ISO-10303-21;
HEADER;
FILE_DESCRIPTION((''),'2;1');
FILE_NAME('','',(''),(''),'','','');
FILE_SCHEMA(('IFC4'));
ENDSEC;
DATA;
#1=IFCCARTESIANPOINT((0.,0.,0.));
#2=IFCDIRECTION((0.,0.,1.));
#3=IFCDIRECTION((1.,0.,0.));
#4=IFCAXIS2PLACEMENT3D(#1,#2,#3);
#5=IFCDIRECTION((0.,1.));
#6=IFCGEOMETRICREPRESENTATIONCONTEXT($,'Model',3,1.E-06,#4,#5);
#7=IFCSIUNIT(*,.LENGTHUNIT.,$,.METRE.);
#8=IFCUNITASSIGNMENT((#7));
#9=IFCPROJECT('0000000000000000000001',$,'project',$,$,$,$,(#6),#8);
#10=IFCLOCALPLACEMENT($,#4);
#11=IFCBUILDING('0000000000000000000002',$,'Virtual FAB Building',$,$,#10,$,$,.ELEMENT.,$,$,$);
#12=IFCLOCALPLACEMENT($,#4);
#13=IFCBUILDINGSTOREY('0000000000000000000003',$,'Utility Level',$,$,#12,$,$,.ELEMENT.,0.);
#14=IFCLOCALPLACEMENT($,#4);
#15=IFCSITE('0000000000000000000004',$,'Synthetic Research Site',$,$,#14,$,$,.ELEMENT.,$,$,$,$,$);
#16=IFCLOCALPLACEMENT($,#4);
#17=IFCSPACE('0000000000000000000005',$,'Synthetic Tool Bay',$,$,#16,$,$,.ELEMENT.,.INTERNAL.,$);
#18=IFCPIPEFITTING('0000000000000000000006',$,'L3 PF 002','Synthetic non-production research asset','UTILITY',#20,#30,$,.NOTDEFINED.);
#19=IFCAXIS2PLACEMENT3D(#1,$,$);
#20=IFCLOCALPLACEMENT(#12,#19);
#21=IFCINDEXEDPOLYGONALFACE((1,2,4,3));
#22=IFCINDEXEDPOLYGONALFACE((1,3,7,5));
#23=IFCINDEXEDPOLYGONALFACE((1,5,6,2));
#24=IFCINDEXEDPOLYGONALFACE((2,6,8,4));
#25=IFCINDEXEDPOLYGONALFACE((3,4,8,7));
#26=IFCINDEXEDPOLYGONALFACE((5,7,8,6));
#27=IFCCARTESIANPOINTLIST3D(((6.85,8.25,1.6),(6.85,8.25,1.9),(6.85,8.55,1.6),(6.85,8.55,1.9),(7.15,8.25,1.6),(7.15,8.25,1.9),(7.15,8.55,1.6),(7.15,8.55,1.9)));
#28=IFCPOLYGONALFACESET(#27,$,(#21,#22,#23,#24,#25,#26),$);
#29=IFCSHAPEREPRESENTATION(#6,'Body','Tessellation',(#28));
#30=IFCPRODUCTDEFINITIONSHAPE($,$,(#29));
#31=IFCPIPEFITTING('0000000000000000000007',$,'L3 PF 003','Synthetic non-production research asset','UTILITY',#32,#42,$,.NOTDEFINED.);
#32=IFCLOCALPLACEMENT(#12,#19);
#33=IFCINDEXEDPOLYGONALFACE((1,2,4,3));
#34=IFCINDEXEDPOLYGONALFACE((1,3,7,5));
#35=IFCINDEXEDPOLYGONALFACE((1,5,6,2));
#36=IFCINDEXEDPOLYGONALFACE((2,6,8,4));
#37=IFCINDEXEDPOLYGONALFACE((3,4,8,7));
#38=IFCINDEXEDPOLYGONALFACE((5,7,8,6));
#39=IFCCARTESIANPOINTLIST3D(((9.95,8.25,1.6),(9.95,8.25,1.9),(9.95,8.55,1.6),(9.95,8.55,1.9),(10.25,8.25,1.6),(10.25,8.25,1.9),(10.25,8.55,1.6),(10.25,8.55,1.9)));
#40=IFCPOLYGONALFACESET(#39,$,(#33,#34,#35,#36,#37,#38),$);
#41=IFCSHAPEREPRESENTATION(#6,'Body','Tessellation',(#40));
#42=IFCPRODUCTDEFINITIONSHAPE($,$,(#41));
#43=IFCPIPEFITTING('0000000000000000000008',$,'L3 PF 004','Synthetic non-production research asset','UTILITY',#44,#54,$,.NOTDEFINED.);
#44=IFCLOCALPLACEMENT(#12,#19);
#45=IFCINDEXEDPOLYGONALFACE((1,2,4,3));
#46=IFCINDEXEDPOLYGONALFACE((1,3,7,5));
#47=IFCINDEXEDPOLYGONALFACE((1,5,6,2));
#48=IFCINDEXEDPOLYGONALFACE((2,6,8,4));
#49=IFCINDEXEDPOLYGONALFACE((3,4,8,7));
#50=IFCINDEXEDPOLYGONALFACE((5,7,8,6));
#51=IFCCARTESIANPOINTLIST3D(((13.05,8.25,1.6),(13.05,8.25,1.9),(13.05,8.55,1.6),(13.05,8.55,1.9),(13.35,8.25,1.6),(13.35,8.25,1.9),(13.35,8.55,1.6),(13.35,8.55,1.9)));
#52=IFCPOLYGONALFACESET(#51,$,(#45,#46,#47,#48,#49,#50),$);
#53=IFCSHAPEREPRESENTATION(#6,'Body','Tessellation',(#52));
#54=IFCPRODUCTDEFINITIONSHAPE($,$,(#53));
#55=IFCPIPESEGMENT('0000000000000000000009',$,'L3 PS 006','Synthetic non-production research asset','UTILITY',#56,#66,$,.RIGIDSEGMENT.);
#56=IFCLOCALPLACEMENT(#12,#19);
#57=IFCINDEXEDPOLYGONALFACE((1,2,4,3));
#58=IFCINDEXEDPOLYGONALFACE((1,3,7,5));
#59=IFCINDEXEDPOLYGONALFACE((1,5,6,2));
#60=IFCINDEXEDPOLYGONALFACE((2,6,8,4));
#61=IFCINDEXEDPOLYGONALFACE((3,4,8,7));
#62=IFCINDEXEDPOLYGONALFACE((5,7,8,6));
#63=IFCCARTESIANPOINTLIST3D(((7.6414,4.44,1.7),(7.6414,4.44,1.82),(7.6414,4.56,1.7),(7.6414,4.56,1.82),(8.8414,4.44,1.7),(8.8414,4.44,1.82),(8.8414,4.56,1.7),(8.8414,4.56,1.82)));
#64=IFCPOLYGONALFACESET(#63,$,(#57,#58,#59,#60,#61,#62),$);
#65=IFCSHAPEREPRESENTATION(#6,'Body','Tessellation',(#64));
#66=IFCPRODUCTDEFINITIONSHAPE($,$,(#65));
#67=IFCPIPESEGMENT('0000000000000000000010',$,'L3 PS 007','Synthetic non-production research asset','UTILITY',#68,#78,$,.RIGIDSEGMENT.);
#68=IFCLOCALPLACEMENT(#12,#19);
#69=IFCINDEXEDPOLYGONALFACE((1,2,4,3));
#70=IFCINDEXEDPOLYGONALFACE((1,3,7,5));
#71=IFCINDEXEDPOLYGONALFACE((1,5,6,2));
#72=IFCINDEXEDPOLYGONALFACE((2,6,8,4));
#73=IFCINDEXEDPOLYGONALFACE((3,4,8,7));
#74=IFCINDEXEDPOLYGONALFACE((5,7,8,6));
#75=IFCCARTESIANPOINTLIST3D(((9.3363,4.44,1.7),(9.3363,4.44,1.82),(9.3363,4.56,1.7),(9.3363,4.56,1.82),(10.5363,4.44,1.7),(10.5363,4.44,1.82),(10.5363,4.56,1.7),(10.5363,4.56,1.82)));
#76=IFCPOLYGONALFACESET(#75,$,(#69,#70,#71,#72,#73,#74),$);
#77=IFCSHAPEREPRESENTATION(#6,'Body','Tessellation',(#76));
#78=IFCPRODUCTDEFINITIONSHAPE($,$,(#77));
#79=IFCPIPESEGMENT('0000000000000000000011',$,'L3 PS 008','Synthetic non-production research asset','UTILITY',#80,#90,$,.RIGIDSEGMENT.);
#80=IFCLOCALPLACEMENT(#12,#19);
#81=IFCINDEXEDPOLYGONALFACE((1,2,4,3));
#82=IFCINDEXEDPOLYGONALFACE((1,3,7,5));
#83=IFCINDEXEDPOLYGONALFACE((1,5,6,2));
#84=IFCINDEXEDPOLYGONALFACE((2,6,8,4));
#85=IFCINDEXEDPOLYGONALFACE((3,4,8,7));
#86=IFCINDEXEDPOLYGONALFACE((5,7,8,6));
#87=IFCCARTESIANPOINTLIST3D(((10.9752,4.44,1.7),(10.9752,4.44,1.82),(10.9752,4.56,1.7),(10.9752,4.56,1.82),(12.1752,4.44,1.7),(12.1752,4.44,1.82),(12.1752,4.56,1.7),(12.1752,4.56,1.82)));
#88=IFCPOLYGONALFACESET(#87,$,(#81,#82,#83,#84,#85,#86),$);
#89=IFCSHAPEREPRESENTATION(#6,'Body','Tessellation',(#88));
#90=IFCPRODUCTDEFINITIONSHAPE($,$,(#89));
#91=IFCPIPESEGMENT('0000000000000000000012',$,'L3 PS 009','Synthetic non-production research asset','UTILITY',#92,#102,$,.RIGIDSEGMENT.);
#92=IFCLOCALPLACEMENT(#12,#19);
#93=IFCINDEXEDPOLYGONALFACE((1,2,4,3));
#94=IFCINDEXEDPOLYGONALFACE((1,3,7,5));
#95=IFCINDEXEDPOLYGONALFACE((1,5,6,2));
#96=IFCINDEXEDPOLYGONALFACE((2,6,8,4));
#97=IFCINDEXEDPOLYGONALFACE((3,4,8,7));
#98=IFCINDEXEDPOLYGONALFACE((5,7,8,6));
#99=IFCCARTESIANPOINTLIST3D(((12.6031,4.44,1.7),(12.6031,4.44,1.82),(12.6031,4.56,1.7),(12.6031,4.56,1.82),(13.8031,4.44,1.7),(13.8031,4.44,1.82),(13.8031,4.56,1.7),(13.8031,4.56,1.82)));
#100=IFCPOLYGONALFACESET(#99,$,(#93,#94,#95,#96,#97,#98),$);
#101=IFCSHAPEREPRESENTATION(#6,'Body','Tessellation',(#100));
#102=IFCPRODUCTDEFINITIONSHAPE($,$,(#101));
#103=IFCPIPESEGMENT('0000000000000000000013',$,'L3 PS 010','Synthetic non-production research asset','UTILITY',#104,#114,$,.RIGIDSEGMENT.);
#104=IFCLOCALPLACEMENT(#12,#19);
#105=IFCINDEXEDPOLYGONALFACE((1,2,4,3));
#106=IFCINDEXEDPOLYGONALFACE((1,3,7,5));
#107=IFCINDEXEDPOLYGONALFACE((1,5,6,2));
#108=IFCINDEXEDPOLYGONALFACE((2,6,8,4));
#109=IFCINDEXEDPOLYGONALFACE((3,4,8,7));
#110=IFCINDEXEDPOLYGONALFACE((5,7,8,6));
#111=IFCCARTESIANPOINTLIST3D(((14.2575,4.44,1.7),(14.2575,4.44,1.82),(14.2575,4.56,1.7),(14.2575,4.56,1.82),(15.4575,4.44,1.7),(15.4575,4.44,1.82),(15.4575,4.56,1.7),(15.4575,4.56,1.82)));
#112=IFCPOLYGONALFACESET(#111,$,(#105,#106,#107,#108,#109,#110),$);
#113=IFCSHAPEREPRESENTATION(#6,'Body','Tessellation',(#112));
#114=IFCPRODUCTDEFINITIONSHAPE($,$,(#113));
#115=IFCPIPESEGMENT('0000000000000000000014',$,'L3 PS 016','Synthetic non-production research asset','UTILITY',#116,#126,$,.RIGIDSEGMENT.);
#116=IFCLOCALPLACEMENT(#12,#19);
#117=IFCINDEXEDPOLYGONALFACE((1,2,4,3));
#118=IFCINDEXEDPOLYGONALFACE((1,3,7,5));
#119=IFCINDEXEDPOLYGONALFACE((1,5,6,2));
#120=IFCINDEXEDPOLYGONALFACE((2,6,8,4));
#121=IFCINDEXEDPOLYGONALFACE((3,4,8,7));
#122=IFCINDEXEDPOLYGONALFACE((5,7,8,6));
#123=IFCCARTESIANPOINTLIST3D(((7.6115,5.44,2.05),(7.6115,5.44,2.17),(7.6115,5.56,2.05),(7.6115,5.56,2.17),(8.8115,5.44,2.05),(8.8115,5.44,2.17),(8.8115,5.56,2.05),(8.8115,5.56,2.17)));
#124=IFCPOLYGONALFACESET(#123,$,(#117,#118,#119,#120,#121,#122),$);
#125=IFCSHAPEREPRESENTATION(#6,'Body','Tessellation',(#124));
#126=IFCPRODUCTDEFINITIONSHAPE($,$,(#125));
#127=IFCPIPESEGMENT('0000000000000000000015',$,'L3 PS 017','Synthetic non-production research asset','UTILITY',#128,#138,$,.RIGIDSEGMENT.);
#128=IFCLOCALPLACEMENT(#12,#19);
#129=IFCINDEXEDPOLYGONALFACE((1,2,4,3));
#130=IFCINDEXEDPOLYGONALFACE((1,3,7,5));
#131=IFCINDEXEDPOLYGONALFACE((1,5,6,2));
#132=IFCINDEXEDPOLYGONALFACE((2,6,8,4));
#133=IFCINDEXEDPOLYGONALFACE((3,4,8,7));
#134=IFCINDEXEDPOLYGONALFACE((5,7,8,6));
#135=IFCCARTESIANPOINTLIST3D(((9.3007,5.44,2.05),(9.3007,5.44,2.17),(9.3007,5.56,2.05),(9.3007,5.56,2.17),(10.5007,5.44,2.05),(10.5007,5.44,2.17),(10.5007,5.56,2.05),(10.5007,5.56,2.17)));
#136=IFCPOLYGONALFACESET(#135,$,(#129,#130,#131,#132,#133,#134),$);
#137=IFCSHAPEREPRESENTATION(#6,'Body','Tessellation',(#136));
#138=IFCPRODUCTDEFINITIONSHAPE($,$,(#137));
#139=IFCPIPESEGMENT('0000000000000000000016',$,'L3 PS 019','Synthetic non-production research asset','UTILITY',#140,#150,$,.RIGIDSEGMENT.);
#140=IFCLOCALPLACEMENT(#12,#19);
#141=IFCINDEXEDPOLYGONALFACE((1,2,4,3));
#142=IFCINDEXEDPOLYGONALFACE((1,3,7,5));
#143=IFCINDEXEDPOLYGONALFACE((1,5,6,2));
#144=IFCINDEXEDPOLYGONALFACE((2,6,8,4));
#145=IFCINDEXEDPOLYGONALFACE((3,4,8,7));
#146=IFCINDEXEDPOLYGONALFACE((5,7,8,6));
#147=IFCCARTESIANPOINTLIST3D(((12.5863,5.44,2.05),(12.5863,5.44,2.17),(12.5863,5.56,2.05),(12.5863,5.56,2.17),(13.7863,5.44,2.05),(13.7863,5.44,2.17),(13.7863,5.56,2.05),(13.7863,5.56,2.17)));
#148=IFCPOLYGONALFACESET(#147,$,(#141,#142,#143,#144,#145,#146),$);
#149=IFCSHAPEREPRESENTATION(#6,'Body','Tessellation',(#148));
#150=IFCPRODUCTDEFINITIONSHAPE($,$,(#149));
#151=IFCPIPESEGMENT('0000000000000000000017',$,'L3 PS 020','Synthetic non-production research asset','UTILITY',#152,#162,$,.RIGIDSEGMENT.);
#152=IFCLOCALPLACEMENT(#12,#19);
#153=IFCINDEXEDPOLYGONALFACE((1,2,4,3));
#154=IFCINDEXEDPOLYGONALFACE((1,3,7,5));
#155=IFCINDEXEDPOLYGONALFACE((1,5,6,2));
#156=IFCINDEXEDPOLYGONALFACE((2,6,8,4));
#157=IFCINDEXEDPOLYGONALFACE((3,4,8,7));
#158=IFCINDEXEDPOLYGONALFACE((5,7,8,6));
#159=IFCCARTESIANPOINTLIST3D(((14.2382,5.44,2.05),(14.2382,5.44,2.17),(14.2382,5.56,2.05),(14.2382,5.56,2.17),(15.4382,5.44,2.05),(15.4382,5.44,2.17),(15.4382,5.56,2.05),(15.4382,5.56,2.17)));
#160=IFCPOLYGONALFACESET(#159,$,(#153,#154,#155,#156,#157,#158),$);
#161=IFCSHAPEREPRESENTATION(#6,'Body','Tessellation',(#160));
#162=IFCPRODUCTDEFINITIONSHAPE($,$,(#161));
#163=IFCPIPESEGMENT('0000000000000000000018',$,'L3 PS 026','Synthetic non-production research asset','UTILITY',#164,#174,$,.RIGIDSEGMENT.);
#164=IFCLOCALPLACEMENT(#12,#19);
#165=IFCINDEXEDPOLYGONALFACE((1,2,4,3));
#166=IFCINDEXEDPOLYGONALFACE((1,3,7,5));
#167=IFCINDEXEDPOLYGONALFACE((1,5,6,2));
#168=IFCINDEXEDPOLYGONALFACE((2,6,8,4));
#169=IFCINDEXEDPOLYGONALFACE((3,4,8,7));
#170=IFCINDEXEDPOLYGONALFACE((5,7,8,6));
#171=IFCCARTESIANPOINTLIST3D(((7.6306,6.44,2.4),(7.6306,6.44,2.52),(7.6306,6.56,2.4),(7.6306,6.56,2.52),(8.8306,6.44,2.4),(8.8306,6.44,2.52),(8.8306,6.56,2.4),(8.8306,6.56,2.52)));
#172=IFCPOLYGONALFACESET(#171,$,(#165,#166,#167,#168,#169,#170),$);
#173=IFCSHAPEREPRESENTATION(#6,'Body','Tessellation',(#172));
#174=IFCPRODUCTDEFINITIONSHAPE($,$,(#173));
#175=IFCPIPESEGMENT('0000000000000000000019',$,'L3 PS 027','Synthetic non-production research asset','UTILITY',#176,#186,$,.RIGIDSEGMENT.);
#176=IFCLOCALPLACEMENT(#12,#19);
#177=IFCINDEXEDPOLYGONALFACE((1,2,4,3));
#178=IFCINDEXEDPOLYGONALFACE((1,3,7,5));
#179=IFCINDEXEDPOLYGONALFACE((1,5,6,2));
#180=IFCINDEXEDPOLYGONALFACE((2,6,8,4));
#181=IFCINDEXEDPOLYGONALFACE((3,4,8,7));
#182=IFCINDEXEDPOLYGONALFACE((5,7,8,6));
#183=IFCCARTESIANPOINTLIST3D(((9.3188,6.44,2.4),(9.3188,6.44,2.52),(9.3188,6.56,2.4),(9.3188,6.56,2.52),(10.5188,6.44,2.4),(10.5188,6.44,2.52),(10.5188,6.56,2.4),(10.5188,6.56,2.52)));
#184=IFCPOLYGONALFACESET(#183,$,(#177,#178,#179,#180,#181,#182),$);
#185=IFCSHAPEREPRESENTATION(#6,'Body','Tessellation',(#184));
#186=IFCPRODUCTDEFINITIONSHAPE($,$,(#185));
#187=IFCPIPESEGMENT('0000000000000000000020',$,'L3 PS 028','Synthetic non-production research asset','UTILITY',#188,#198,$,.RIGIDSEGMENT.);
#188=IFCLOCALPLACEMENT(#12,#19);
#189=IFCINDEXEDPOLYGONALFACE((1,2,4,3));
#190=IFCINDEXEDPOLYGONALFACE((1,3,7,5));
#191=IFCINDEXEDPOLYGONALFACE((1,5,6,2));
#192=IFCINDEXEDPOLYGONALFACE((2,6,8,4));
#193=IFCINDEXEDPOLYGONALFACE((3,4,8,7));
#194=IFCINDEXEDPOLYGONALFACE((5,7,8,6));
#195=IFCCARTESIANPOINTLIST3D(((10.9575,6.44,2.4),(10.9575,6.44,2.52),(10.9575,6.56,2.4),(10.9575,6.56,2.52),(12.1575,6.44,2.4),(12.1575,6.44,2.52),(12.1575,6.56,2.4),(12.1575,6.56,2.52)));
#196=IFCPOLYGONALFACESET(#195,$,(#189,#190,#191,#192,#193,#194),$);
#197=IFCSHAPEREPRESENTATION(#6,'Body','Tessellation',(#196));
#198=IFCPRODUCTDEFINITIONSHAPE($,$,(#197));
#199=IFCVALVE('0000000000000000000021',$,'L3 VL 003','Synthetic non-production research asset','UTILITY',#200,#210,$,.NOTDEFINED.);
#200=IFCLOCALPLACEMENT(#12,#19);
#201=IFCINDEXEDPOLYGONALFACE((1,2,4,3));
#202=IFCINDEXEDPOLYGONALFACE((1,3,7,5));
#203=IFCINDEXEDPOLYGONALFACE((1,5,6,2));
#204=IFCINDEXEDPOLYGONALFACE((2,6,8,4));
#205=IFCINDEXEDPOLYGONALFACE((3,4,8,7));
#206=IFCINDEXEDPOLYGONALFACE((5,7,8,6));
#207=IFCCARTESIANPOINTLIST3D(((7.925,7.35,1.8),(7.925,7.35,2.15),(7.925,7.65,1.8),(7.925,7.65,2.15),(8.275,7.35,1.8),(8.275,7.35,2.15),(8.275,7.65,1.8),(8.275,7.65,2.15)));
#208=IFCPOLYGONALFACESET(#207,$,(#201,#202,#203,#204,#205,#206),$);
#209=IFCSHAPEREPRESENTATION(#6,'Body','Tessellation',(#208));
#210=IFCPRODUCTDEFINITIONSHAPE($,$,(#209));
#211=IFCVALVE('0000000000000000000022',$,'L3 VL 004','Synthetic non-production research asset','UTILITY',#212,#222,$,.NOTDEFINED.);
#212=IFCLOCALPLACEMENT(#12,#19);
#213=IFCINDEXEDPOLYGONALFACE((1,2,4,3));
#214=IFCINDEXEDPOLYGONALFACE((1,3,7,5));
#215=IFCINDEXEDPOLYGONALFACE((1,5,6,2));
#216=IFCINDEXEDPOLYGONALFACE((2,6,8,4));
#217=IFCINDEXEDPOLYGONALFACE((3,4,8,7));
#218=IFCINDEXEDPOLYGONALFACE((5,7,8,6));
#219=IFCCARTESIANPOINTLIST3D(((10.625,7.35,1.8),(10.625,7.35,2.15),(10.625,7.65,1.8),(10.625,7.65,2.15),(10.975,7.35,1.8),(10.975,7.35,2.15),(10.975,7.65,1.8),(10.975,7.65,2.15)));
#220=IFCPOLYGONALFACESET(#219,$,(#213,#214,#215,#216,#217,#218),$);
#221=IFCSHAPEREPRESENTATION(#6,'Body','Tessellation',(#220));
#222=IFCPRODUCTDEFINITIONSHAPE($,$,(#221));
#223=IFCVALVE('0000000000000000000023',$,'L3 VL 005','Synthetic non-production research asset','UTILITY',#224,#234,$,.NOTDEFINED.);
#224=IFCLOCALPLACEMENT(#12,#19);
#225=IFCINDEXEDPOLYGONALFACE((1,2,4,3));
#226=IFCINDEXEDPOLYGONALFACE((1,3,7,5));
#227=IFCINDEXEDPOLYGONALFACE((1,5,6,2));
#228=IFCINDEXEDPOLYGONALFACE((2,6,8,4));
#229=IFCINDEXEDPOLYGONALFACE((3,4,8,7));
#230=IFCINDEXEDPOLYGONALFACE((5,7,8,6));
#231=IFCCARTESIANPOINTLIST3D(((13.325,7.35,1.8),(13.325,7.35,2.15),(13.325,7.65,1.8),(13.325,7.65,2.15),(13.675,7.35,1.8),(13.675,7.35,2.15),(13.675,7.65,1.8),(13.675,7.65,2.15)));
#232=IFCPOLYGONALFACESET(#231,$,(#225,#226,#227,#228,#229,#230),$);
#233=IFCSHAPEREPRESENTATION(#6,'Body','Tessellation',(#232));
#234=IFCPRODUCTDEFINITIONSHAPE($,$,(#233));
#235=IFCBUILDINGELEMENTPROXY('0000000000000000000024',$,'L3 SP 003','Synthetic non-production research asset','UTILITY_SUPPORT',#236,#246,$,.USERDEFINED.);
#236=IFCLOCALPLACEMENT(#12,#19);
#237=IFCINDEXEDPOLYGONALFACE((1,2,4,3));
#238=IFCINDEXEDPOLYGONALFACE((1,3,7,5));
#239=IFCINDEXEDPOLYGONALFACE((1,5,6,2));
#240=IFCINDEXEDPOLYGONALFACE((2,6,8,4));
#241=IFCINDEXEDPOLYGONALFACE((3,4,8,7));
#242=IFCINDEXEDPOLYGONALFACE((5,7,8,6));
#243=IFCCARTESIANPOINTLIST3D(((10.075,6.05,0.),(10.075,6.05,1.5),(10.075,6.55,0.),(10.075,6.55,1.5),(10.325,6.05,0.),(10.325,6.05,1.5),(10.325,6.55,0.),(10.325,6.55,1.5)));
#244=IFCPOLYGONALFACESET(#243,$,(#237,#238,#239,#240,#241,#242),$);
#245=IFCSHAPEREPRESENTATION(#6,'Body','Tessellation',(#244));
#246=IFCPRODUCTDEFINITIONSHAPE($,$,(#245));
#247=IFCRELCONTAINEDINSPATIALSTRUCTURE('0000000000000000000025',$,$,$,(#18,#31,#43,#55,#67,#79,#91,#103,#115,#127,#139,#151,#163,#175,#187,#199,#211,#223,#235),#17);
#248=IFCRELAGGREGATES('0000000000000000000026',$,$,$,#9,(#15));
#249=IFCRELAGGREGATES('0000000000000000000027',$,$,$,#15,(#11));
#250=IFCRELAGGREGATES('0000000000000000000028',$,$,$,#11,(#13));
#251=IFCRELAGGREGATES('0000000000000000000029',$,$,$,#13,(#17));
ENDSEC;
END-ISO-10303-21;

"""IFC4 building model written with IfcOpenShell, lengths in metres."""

from ifc_helpers import new_model, si_unit, direction, frame, origin_with_axes, origin_2d_with_axis, place, context, project, spatial, rectangle, extrude, element, save


model = new_model("IFC4")

# Units and contexts
model_context = context("Model", 3, precision=1e-06, world=origin_with_axes(), true_north=direction((0.0, 1.0)))
ifc_project = project(units=[si_unit("LENGTHUNIT", "METRE")], contexts=[model_context])

# Site, building, storey, space
site_placement = place(None, origin_with_axes())
site = spatial("IfcSite", under=ifc_project, at=site_placement, Name="Synthetic Research Site", CompositionType="ELEMENT")
building_placement = place(None, origin_with_axes())
building = spatial("IfcBuilding", under=site, at=building_placement, Name="Virtual FAB Building", CompositionType="ELEMENT")
storey_placement = place(None, origin_with_axes())
storey = spatial("IfcBuildingStorey", under=building, at=storey_placement, Name="Utility Level", CompositionType="ELEMENT", Elevation=0.0)
space_placement = place(None, origin_with_axes())
space = spatial("IfcSpace", under=storey, at=space_placement, Name="Synthetic Tool Bay", CompositionType="ELEMENT", PredefinedType="INTERNAL")

# Pipe fittings
for number, where, z_axis, x_axis, name in (
    (1, (7.0, 8.4, 1.6), (0.0, 0.0, 1.0), (1.0, 0.0, 0.0), "L3 PF 002"),
    (2, (10.1, 8.4, 1.6), (0.0, 0.0, 1.0), (1.0, 0.0, 0.0), "L3 PF 003"),
    (3, (13.2, 8.4, 1.6), (0.0, 0.0, 1.0), (1.0, 0.0, 0.0), "L3 PF 004"),
):
    element("IfcPipeFitting", number, at=place(None, frame(where, z_axis=z_axis, x_axis=x_axis)), inside=space, Name=name, Description="Synthetic non-production research asset", ObjectType="UTILITY", PredefinedType="NOTDEFINED", context=model_context, shape_type="SweptSolid", body=[
        extrude(rectangle(XDim=0.3, YDim=0.3, at=origin_2d_with_axis()), origin_with_axes(), (0.0, 0.0, 1.0), 0.3),
    ])

# Pipe segments
for number, where, z_axis, x_axis, name in (
    (4, (8.2414, 4.5, 1.7), (0.0, 0.0, 1.0), (1.0, 0.0, 0.0), "L3 PS 006"),
    (5, (9.9363, 4.5, 1.7), (0.0, 0.0, 1.0), (1.0, 0.0, 0.0), "L3 PS 007"),
    (6, (11.5752, 4.5, 1.7), (0.0, 0.0, 1.0), (1.0, 0.0, 0.0), "L3 PS 008"),
    (7, (13.2031, 4.5, 1.7), (0.0, 0.0, 1.0), (1.0, 0.0, 0.0), "L3 PS 009"),
    (8, (14.8575, 4.5, 1.7), (0.0, 0.0, 1.0), (1.0, 0.0, 0.0), "L3 PS 010"),
    (9, (8.2115, 5.5, 2.05), (0.0, 0.0, 1.0), (1.0, 0.0, 0.0), "L3 PS 016"),
    (10, (9.9007, 5.5, 2.05), (0.0, 0.0, 1.0), (1.0, 0.0, 0.0), "L3 PS 017"),
    (11, (13.1863, 5.5, 2.05), (0.0, 0.0, 1.0), (1.0, 0.0, 0.0), "L3 PS 019"),
    (12, (14.8382, 5.5, 2.05), (0.0, 0.0, 1.0), (1.0, 0.0, 0.0), "L3 PS 020"),
    (13, (8.2306, 6.5, 2.4), (0.0, 0.0, 1.0), (1.0, 0.0, 0.0), "L3 PS 026"),
    (14, (9.9188, 6.5, 2.4), (0.0, 0.0, 1.0), (1.0, 0.0, 0.0), "L3 PS 027"),
    (15, (11.5575, 6.5, 2.4), (0.0, 0.0, 1.0), (1.0, 0.0, 0.0), "L3 PS 028"),
):
    element("IfcPipeSegment", number, at=place(None, frame(where, z_axis=z_axis, x_axis=x_axis)), inside=space, Name=name, Description="Synthetic non-production research asset", ObjectType="UTILITY", PredefinedType="RIGIDSEGMENT", context=model_context, shape_type="SweptSolid", body=[
        extrude(rectangle(XDim=1.2, YDim=0.12, at=origin_2d_with_axis()), origin_with_axes(), (0.0, 0.0, 1.0), 0.12),
    ])

# Valves
for number, where, z_axis, x_axis, name in (
    (16, (8.1, 7.5, 1.8), (0.0, 0.0, 1.0), (1.0, 0.0, 0.0), "L3 VL 003"),
    (17, (10.8, 7.5, 1.8), (0.0, 0.0, 1.0), (1.0, 0.0, 0.0), "L3 VL 004"),
    (18, (13.5, 7.5, 1.8), (0.0, 0.0, 1.0), (1.0, 0.0, 0.0), "L3 VL 005"),
):
    element("IfcValve", number, at=place(None, frame(where, z_axis=z_axis, x_axis=x_axis)), inside=space, Name=name, Description="Synthetic non-production research asset", ObjectType="UTILITY", PredefinedType="NOTDEFINED", context=model_context, shape_type="SweptSolid", body=[
        extrude(rectangle(XDim=0.35, YDim=0.3, at=origin_2d_with_axis()), origin_with_axes(), (0.0, 0.0, 1.0), 0.35),
    ])

# Building element proxy
for number, where, z_axis, x_axis, name in (
    (19, (10.2, 6.3, 0.0), (0.0, 0.0, 1.0), (1.0, 0.0, 0.0), "L3 SP 003"),
):
    element("IfcBuildingElementProxy", number, at=place(None, frame(where, z_axis=z_axis, x_axis=x_axis)), inside=space, Name=name, Description="Synthetic non-production research asset", ObjectType="UTILITY_SUPPORT", PredefinedType="USERDEFINED", context=model_context, shape_type="SweptSolid", body=[
        extrude(rectangle(XDim=0.25, YDim=0.5, at=origin_2d_with_axis()), origin_with_axes(), (0.0, 0.0, 1.0), 1.5),
    ])

save(model, "model.ifc")
